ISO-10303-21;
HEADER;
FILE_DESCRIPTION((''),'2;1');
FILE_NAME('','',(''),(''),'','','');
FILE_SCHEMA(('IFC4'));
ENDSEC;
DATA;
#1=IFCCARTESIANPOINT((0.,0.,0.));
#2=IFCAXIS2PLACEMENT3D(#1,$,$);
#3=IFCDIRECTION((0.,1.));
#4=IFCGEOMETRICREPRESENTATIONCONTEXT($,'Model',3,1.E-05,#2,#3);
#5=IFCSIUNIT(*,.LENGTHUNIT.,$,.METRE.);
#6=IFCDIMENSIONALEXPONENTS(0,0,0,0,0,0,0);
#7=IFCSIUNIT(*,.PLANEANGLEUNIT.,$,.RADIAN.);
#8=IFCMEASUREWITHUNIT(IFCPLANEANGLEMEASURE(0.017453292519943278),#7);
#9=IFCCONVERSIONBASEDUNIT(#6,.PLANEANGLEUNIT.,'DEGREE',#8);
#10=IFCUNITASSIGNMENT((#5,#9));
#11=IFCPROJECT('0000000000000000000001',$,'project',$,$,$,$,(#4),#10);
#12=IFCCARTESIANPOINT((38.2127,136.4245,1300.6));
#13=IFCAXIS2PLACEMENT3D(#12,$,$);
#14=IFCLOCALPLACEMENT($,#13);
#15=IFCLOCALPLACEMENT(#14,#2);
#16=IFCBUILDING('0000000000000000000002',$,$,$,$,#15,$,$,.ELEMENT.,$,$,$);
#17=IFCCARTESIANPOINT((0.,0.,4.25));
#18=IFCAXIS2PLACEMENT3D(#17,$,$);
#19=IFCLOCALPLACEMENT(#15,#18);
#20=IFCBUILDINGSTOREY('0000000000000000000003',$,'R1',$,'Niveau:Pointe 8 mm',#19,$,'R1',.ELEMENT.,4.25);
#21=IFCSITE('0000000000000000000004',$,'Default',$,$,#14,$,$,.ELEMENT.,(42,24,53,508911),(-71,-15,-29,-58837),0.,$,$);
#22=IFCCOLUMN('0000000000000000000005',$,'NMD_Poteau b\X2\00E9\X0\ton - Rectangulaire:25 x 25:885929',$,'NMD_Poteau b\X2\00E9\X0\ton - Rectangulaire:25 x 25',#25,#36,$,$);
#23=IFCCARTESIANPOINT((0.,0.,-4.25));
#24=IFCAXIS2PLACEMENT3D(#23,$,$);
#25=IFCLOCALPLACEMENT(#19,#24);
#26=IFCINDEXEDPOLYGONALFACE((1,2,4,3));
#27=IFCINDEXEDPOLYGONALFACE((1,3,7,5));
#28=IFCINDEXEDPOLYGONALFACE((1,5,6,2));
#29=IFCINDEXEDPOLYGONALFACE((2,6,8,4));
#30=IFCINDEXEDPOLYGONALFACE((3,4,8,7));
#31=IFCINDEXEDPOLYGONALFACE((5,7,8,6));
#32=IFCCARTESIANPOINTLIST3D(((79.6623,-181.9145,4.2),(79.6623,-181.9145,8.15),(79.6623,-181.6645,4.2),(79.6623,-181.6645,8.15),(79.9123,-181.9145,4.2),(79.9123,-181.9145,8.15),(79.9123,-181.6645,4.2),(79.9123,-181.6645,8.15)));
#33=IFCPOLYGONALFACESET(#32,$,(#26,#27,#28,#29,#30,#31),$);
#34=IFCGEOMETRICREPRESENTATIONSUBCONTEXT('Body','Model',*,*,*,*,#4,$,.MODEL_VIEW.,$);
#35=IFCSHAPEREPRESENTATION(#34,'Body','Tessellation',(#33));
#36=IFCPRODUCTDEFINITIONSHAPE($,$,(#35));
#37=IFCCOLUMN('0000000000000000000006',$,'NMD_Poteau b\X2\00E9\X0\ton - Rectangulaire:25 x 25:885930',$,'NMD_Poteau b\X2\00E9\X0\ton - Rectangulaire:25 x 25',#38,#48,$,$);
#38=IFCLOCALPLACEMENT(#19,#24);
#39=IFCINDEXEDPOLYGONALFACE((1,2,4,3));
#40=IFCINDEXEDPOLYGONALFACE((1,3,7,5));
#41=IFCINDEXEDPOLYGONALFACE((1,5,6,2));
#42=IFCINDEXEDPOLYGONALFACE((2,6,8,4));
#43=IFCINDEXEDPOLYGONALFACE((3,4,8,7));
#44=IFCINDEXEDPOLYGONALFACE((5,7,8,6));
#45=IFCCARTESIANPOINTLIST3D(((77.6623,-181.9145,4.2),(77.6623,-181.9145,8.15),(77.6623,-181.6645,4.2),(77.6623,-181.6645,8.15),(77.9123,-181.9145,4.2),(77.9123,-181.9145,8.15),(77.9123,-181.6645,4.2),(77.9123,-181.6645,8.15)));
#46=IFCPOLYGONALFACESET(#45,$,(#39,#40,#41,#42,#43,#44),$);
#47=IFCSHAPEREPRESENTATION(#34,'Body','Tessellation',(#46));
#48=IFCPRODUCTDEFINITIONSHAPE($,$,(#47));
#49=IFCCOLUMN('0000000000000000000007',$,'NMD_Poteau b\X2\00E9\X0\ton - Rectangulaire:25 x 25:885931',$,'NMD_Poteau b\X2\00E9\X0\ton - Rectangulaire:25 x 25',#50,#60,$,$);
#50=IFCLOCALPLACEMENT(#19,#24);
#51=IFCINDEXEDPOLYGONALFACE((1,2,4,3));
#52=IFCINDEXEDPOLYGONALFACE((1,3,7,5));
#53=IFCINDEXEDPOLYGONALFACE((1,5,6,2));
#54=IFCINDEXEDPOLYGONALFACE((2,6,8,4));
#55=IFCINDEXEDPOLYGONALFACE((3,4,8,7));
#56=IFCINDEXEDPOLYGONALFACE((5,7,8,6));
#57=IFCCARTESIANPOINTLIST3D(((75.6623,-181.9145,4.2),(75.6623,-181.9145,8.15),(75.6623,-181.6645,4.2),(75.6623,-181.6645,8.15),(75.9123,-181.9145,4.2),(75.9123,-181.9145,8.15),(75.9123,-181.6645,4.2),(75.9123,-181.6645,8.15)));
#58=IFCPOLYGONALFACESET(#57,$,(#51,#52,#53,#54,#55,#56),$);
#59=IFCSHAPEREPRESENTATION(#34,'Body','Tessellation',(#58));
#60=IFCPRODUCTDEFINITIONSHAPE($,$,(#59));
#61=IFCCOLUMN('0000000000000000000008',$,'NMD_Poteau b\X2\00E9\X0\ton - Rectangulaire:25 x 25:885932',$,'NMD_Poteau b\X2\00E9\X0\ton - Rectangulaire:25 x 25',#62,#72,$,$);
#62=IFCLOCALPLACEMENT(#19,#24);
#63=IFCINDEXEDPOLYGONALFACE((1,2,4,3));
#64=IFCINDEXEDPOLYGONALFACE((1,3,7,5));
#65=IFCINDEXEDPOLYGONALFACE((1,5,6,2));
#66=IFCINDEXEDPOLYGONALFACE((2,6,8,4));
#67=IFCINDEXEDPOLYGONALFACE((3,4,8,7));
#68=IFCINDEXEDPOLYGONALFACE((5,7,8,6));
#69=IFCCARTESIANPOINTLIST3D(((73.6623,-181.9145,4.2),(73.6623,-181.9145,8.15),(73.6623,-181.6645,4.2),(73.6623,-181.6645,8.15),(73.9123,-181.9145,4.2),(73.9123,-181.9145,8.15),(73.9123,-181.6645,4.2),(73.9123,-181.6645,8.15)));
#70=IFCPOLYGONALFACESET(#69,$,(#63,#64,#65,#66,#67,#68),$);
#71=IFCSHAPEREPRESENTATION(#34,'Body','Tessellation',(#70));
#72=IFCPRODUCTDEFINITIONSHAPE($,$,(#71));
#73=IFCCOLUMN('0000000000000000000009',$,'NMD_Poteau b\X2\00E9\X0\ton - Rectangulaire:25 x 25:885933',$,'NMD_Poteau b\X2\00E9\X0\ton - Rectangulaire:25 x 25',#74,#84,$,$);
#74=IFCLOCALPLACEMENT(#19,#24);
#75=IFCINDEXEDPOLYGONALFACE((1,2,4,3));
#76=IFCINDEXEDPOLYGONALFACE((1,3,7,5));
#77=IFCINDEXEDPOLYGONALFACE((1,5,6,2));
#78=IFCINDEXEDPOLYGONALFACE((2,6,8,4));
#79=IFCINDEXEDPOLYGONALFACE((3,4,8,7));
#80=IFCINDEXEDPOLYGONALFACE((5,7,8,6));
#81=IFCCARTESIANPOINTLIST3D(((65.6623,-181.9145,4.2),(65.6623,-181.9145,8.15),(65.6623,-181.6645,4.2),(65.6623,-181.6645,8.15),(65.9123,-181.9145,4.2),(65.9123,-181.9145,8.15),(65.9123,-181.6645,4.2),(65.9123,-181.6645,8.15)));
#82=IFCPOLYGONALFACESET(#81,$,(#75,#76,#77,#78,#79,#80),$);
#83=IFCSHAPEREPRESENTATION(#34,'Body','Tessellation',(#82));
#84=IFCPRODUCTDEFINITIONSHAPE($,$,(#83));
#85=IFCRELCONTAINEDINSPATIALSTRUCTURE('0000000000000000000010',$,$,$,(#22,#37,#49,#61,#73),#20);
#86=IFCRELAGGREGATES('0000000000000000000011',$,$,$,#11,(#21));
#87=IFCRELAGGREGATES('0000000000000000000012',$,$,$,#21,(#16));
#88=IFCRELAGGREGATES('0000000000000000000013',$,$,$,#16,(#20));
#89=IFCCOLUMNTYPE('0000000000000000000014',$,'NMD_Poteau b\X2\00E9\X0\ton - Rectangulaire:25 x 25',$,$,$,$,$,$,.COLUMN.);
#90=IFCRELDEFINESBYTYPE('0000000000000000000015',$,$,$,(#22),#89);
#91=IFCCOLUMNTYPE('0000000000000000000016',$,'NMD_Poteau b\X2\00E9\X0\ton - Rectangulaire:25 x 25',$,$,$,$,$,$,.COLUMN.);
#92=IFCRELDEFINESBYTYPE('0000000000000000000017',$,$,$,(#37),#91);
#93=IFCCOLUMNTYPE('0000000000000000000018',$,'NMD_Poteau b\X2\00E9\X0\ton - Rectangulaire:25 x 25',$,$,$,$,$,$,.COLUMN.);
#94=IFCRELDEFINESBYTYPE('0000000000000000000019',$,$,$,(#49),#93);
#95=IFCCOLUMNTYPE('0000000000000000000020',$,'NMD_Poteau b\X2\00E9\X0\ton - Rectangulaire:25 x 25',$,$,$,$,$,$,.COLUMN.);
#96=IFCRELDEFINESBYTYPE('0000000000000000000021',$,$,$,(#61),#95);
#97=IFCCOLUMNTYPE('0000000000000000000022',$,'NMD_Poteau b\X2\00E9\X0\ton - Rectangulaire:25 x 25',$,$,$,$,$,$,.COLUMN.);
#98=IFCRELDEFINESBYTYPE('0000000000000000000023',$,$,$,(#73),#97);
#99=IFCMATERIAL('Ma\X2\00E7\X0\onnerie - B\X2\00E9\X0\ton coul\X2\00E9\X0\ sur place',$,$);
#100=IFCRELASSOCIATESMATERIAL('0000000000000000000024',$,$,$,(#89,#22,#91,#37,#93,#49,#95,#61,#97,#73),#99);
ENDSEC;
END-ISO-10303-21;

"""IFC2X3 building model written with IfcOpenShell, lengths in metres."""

from ifc_helpers import new_model, entity, si_unit, converted_unit, direction, frame, frame_2d, origin, place, context, subcontext, project, spatial, rectangle, extrude, source, transform, mapped, material, type_object, type_shapes, element, save


model = new_model("IFC2X3")

# Units and contexts
model_context = context("Model", 3, precision=1e-05, world=origin(), true_north=direction((0.0, 1.0)))
body_context = subcontext(model_context, "Body", "Model", "MODEL_VIEW")
ifc_project = project(units=[si_unit("LENGTHUNIT", "METRE"), converted_unit("PLANEANGLEUNIT", "DEGREE", entity("IfcPlaneAngleMeasure", 0.017453292519943278), si_unit("PLANEANGLEUNIT", "RADIAN"), dimensions=[0, 0, 0, 0, 0, 0, 0])], contexts=[model_context])

# Site, building, storey
site_placement = place(None, frame((38.2127, 136.4245, 1300.6)))
site = spatial("IfcSite", under=ifc_project, at=site_placement, Name="Default", CompositionType="ELEMENT", RefLatitude=(42, 24, 53, 508911), RefLongitude=(-71, -15, -29, -58837), RefElevation=0.0)
building_placement = place(site_placement, origin())
building = spatial("IfcBuilding", under=site, at=building_placement, CompositionType="ELEMENT")
storey_placement = place(building_placement, frame((0.0, 0.0, 4.25)))
storey = spatial("IfcBuildingStorey", under=building, at=storey_placement, Name="R1", ObjectType="Niveau:Pointe 8 mm", LongName="R1", CompositionType="ELEMENT", Elevation=4.25)

# Columns
ifc_material = material(Name="Maçonnerie - Béton coulé sur place")
column_type_1 = type_object("IfcColumnType", Name="NMD_Poteau béton - Rectangulaire:25 x 25", PredefinedType="COLUMN", material=ifc_material)
shared_shape_1 = source(origin(), body_context, "Body", "SweptSolid", [
    extrude(rectangle(XDim=0.25, YDim=0.25, at=frame_2d((0.0, 0.0), x_axis=(1.0, 0.0))), frame((79.7873, -181.7895, 4.2), z_axis=(0.0, 0.0, 1.0), x_axis=(-1.0, 0.0, 0.0)), (0.0, 0.0, 1.0), 3.95),
])
type_shapes(column_type_1, [shared_shape_1])
column_1_placement = place(storey_placement, frame((0.0, 0.0, -4.25)))
element("IfcColumn", 1, at=column_1_placement, inside=storey, type_object=column_type_1, material=ifc_material, Name="NMD_Poteau béton - Rectangulaire:25 x 25:885929", ObjectType="NMD_Poteau béton - Rectangulaire:25 x 25", context=body_context, shape_type="MappedRepresentation", body=[
    mapped(shared_shape_1, transform((0.0, 0.0, 0.0), scale=1.0)),
])
column_type_2 = type_object("IfcColumnType", Name="NMD_Poteau béton - Rectangulaire:25 x 25", PredefinedType="COLUMN", material=ifc_material)
shared_shape_2 = source(origin(), body_context, "Body", "SweptSolid", [
    extrude(rectangle(XDim=0.25, YDim=0.25, at=frame_2d((0.0, 0.0), x_axis=(1.0, 0.0))), frame((77.7873, -181.7895, 4.2), z_axis=(0.0, 0.0, 1.0), x_axis=(-1.0, 0.0, 0.0)), (0.0, 0.0, 1.0), 3.95),
])
type_shapes(column_type_2, [shared_shape_2])
column_2_placement = place(storey_placement, frame((0.0, 0.0, -4.25)))
element("IfcColumn", 2, at=column_2_placement, inside=storey, type_object=column_type_2, material=ifc_material, Name="NMD_Poteau béton - Rectangulaire:25 x 25:885930", ObjectType="NMD_Poteau béton - Rectangulaire:25 x 25", context=body_context, shape_type="MappedRepresentation", body=[
    mapped(shared_shape_2, transform((0.0, 0.0, 0.0), scale=1.0)),
])
column_type_3 = type_object("IfcColumnType", Name="NMD_Poteau béton - Rectangulaire:25 x 25", PredefinedType="COLUMN", material=ifc_material)
shared_shape_3 = source(origin(), body_context, "Body", "SweptSolid", [
    extrude(rectangle(XDim=0.25, YDim=0.25, at=frame_2d((0.0, 0.0), x_axis=(1.0, 0.0))), frame((75.7873, -181.7895, 4.2), z_axis=(0.0, 0.0, 1.0), x_axis=(-1.0, 0.0, 0.0)), (0.0, 0.0, 1.0), 3.95),
])
type_shapes(column_type_3, [shared_shape_3])
column_3_placement = place(storey_placement, frame((0.0, 0.0, -4.25)))
element("IfcColumn", 3, at=column_3_placement, inside=storey, type_object=column_type_3, material=ifc_material, Name="NMD_Poteau béton - Rectangulaire:25 x 25:885931", ObjectType="NMD_Poteau béton - Rectangulaire:25 x 25", context=body_context, shape_type="MappedRepresentation", body=[
    mapped(shared_shape_3, transform((0.0, 0.0, 0.0), scale=1.0)),
])
column_type_4 = type_object("IfcColumnType", Name="NMD_Poteau béton - Rectangulaire:25 x 25", PredefinedType="COLUMN", material=ifc_material)
shared_shape_4 = source(origin(), body_context, "Body", "SweptSolid", [
    extrude(rectangle(XDim=0.25, YDim=0.25, at=frame_2d((0.0, 0.0), x_axis=(1.0, 0.0))), frame((73.7873, -181.7895, 4.2), z_axis=(0.0, 0.0, 1.0), x_axis=(-1.0, 0.0, 0.0)), (0.0, 0.0, 1.0), 3.95),
])
type_shapes(column_type_4, [shared_shape_4])
column_4_placement = place(storey_placement, frame((0.0, 0.0, -4.25)))
element("IfcColumn", 4, at=column_4_placement, inside=storey, type_object=column_type_4, material=ifc_material, Name="NMD_Poteau béton - Rectangulaire:25 x 25:885932", ObjectType="NMD_Poteau béton - Rectangulaire:25 x 25", context=body_context, shape_type="MappedRepresentation", body=[
    mapped(shared_shape_4, transform((0.0, 0.0, 0.0), scale=1.0)),
])
column_type_5 = type_object("IfcColumnType", Name="NMD_Poteau béton - Rectangulaire:25 x 25", PredefinedType="COLUMN", material=ifc_material)
shared_shape_5 = source(origin(), body_context, "Body", "SweptSolid", [
    extrude(rectangle(XDim=0.25, YDim=0.25, at=frame_2d((0.0, 0.0), x_axis=(1.0, 0.0))), frame((65.7873, -181.7895, 4.2), z_axis=(0.0, 0.0, 1.0), x_axis=(-1.0, 0.0, 0.0)), (0.0, 0.0, 1.0), 3.95),
])
type_shapes(column_type_5, [shared_shape_5])
column_5_placement = place(storey_placement, frame((0.0, 0.0, -4.25)))
element("IfcColumn", 5, at=column_5_placement, inside=storey, type_object=column_type_5, material=ifc_material, Name="NMD_Poteau béton - Rectangulaire:25 x 25:885933", ObjectType="NMD_Poteau béton - Rectangulaire:25 x 25", context=body_context, shape_type="MappedRepresentation", body=[
    mapped(shared_shape_5, transform((0.0, 0.0, 0.0), scale=1.0)),
])

save(model, "model.ifc")
